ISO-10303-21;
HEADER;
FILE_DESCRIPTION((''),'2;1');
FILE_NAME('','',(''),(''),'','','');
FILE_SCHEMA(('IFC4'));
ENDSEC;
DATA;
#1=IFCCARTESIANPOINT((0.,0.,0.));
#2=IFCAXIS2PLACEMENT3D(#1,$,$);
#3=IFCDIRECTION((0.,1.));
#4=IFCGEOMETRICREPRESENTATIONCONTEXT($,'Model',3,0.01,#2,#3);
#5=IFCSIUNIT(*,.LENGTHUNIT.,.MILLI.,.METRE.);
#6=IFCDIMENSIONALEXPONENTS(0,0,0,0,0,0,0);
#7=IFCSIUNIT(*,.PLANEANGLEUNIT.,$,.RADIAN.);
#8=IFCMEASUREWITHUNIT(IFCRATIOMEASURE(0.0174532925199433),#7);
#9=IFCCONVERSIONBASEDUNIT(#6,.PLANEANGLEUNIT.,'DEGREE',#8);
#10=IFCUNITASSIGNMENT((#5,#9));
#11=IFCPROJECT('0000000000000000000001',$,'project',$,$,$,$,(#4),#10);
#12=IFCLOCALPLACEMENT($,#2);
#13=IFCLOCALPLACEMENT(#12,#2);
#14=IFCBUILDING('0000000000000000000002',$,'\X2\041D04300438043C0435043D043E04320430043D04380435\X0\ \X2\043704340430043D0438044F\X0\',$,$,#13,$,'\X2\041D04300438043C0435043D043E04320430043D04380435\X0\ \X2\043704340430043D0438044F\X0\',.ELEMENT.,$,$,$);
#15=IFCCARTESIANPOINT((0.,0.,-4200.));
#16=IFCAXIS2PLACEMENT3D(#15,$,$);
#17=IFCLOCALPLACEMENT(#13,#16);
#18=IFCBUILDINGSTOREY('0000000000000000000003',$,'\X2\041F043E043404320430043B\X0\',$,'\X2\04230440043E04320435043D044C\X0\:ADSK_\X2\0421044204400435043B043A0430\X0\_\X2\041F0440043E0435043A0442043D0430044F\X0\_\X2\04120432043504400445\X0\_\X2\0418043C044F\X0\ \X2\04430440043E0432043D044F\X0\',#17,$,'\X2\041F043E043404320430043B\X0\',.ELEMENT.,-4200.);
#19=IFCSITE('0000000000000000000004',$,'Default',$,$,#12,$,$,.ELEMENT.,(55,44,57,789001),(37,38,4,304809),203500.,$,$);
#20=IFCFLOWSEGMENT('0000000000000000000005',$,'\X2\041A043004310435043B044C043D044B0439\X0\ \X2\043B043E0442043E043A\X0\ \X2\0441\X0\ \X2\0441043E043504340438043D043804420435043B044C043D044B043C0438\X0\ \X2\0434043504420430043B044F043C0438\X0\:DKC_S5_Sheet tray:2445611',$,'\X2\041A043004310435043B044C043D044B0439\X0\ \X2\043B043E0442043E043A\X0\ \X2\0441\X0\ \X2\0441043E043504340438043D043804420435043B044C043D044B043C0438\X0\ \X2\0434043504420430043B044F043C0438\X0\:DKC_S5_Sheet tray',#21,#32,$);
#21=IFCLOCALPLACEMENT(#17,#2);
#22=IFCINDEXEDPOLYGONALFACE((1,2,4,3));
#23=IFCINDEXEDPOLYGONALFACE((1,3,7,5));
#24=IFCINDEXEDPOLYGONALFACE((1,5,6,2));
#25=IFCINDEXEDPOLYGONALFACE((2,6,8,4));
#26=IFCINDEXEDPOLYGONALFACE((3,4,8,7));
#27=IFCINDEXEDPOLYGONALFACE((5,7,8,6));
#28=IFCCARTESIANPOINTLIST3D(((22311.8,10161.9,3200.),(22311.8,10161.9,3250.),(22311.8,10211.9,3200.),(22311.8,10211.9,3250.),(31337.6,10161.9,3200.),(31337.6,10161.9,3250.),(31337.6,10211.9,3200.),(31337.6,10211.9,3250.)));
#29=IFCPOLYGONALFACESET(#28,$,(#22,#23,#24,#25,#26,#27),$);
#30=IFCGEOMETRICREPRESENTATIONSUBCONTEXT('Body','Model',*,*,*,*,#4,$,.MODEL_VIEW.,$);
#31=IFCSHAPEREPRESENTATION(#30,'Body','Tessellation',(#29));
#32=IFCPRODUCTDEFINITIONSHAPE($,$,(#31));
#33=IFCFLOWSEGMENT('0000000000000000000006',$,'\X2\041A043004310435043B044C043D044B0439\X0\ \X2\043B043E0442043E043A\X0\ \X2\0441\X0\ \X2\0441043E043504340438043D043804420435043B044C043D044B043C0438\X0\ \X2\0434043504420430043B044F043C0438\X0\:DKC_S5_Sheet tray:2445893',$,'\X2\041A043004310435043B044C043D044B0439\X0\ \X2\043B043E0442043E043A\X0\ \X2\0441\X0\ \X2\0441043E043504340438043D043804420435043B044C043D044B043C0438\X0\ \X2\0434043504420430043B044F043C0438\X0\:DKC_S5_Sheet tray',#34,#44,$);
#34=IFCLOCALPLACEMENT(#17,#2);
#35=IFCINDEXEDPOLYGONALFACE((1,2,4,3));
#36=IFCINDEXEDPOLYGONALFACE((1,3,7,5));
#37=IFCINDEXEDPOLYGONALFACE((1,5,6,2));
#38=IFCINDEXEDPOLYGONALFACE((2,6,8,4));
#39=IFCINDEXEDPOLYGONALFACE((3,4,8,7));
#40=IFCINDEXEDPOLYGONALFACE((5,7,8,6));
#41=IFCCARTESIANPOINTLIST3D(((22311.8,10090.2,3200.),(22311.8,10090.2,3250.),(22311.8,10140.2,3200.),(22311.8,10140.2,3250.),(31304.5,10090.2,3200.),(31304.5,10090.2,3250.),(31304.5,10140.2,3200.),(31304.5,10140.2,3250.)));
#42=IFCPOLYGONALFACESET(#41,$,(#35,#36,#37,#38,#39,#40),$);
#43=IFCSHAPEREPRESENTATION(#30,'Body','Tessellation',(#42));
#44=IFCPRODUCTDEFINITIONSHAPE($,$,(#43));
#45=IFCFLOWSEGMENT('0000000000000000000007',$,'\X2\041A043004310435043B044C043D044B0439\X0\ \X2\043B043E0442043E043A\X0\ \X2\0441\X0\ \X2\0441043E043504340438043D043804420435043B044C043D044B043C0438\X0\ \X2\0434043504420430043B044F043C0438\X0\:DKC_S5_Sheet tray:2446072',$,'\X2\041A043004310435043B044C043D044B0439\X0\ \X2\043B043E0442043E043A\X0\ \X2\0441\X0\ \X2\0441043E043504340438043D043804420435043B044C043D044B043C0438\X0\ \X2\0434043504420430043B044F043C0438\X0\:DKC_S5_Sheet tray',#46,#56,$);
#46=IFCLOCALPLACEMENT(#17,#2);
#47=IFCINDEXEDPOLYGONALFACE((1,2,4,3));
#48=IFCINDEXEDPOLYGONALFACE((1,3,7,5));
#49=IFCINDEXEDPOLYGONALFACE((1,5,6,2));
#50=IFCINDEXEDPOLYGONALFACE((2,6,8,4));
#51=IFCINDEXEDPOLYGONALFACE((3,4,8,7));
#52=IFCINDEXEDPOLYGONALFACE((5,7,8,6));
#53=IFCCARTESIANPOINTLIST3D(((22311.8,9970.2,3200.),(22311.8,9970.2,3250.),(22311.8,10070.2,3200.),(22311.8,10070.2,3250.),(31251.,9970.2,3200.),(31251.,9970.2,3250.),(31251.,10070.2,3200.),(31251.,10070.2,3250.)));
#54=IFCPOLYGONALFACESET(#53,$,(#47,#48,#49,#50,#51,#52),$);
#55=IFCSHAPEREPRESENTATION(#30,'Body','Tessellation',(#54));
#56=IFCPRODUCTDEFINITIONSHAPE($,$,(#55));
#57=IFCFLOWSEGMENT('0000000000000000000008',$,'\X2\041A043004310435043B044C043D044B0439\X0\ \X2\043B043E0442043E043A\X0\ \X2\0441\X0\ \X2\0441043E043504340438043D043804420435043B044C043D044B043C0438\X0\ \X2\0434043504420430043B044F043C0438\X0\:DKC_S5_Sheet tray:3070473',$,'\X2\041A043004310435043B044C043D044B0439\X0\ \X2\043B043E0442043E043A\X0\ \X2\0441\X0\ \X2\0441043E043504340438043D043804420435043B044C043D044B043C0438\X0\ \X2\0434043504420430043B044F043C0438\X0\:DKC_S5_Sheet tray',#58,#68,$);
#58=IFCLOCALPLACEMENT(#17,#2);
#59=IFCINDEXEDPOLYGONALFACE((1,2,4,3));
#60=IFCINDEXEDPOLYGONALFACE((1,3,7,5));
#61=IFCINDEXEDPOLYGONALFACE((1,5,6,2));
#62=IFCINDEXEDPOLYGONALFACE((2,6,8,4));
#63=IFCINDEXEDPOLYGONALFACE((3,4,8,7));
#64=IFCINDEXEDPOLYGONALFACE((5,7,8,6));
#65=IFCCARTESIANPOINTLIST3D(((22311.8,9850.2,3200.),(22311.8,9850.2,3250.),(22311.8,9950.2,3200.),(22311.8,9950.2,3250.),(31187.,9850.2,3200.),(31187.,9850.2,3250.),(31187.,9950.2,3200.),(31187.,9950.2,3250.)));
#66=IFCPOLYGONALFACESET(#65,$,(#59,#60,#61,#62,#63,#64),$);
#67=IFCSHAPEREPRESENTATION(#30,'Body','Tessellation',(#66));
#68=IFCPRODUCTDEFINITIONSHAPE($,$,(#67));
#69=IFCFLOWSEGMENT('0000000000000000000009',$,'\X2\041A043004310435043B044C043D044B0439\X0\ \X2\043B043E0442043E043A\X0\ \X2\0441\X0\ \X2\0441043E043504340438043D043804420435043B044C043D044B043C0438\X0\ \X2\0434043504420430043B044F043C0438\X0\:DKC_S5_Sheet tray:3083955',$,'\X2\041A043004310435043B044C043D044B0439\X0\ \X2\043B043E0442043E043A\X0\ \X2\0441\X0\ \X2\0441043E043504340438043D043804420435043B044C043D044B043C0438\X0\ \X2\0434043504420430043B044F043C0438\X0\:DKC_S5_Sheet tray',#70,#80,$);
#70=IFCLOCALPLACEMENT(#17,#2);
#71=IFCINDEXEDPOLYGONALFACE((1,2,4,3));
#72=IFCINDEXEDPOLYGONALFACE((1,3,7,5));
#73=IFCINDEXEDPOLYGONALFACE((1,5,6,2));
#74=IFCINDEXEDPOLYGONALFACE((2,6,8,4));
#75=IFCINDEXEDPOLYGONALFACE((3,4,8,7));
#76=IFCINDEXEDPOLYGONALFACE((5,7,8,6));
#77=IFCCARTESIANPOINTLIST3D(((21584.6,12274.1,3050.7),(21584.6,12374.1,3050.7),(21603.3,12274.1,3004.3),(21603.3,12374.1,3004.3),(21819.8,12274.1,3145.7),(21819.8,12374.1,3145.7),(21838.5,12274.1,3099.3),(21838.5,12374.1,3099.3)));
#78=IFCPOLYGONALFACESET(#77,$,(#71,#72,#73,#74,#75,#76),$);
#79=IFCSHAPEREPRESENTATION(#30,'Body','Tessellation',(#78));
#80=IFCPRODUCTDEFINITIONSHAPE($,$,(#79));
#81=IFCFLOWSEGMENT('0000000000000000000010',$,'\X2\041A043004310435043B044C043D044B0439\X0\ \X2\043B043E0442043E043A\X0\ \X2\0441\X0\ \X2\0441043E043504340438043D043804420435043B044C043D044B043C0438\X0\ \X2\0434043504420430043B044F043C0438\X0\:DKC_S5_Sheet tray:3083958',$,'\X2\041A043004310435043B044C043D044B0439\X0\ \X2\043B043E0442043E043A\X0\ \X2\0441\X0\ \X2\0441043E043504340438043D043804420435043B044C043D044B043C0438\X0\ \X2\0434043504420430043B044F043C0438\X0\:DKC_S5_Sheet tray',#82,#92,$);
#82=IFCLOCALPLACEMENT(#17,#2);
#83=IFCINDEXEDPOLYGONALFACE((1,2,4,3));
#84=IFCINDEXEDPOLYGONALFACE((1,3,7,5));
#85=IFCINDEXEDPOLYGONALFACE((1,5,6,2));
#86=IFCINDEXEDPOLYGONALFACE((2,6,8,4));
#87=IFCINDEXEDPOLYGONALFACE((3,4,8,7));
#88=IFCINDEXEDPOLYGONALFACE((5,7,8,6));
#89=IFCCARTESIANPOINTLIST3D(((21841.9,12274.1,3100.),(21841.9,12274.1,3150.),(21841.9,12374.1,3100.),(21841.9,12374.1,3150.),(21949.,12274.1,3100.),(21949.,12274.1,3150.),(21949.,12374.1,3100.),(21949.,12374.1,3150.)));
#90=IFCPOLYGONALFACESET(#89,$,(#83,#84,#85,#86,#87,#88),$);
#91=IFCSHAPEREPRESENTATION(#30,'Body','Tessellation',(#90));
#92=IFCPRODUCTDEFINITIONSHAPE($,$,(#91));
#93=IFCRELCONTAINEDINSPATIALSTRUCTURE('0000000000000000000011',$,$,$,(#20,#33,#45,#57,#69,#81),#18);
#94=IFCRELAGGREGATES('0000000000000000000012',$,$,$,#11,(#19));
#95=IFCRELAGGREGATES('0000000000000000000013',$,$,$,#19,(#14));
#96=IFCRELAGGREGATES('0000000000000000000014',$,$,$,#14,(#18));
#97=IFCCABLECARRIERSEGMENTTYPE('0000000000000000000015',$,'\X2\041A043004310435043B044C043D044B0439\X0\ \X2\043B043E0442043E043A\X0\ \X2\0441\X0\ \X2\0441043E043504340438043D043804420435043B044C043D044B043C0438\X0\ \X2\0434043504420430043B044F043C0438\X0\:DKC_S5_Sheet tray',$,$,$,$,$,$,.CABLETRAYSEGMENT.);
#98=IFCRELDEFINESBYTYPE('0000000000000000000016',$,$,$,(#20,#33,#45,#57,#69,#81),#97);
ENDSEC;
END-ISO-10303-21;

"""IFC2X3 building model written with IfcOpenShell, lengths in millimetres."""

from ifc_helpers import new_model, entity, si_unit, converted_unit, direction, frame, frame_2d, origin, origin_2d_with_axis, place, context, subcontext, project, spatial, rectangle, extrude, type_object, element, save


model = new_model("IFC2X3")

# Units and contexts
model_context = context("Model", 3, precision=0.01, world=origin(), true_north=direction((0.0, 1.0)))
body_context = subcontext(model_context, "Body", "Model", "MODEL_VIEW")
ifc_project = project(units=[si_unit("LENGTHUNIT", "METRE", prefix="MILLI"), converted_unit("PLANEANGLEUNIT", "DEGREE", entity("IfcRatioMeasure", 0.0174532925199433), si_unit("PLANEANGLEUNIT", "RADIAN"), dimensions=[0, 0, 0, 0, 0, 0, 0])], contexts=[model_context])

# Site, building, storey
site_placement = place(None, origin())
site = spatial("IfcSite", under=ifc_project, at=site_placement, Name="Default", CompositionType="ELEMENT", RefLatitude=(55, 44, 57, 789001), RefLongitude=(37, 38, 4, 304809), RefElevation=203500.0)
building_placement = place(site_placement, origin())
building = spatial("IfcBuilding", under=site, at=building_placement, Name="Наименование здания", LongName="Наименование здания", CompositionType="ELEMENT")
storey_placement = place(building_placement, frame((0.0, 0.0, -4200.0)))
storey = spatial("IfcBuildingStorey", under=building, at=storey_placement, Name="Подвал", ObjectType="Уровень:ADSK_Стрелка_Проектная_Вверх_Имя уровня", LongName="Подвал", CompositionType="ELEMENT", Elevation=-4200.0)

# Flow segments
cable_carrier_segment_type = type_object("IfcCableCarrierSegmentType", Name="Кабельный лоток с соединительными деталями:DKC_S5_Sheet tray", PredefinedType="CABLETRAYSEGMENT")
flow_segment_1_placement = place(storey_placement, frame((22311.8, 10161.9, 3200.0)))
element("IfcFlowSegment", 1, at=flow_segment_1_placement, inside=storey, type_object=cable_carrier_segment_type, Name="Кабельный лоток с соединительными деталями:DKC_S5_Sheet tray:2445611", ObjectType="Кабельный лоток с соединительными деталями:DKC_S5_Sheet tray", context=body_context, shape_type="SweptSolid", body=[
    extrude(rectangle(XDim=9025.9, YDim=50.0, at=origin_2d_with_axis()), frame((4512.9, 25.0, 0.0)), (0.0, 0.0, 1.0), 50.0),
])
flow_segment_2_placement = place(storey_placement, frame((22311.8, 10090.1, 3200.0)))
element("IfcFlowSegment", 2, at=flow_segment_2_placement, inside=storey, type_object=cable_carrier_segment_type, Name="Кабельный лоток с соединительными деталями:DKC_S5_Sheet tray:2445893", ObjectType="Кабельный лоток с соединительными деталями:DKC_S5_Sheet tray", context=body_context, shape_type="SweptSolid", body=[
    extrude(rectangle(XDim=8992.7, YDim=50.0, at=origin_2d_with_axis()), frame((4496.4, 25.0, 0.0)), (0.0, 0.0, 1.0), 50.0),
])
flow_segment_3_placement = place(storey_placement, frame((22311.8, 9970.1, 3200.0)))
element("IfcFlowSegment", 3, at=flow_segment_3_placement, inside=storey, type_object=cable_carrier_segment_type, Name="Кабельный лоток с соединительными деталями:DKC_S5_Sheet tray:2446072", ObjectType="Кабельный лоток с соединительными деталями:DKC_S5_Sheet tray", context=body_context, shape_type="SweptSolid", body=[
    extrude(rectangle(XDim=8939.2, YDim=100.0, at=origin_2d_with_axis()), frame((4469.6, 50.0, 0.0)), (0.0, 0.0, 1.0), 50.0),
])
flow_segment_4_placement = place(storey_placement, frame((22311.8, 9850.1, 3200.0)))
element("IfcFlowSegment", 4, at=flow_segment_4_placement, inside=storey, type_object=cable_carrier_segment_type, Name="Кабельный лоток с соединительными деталями:DKC_S5_Sheet tray:3070473", ObjectType="Кабельный лоток с соединительными деталями:DKC_S5_Sheet tray", context=body_context, shape_type="SweptSolid", body=[
    extrude(rectangle(XDim=8875.2, YDim=100.0, at=origin_2d_with_axis()), frame((4437.6, 50.0, 0.0)), (0.0, 0.0, 1.0), 50.0),
])
flow_segment_5_placement = place(storey_placement, frame((21584.6, 12274.1, 3004.3)))
element("IfcFlowSegment", 5, at=flow_segment_5_placement, inside=storey, type_object=cable_carrier_segment_type, Name="Кабельный лоток с соединительными деталями:DKC_S5_Sheet tray:3083955", ObjectType="Кабельный лоток с соединительными деталями:DKC_S5_Sheet tray", context=body_context, shape_type="SweptSolid", body=[
    extrude(rectangle(XDim=50.0, YDim=100.0, at=frame_2d((0.0, 0.0), x_axis=(0.0, 1.0))), frame((9.4, 50.0, 23.2), z_axis=(0.927184, 0.0, 0.374607), x_axis=(0.0, 1.0, 0.0)), (0.0, 0.0, 1.0), 253.7),
])
flow_segment_6_placement = place(storey_placement, frame((21841.9, 12274.1, 3100.0)))
element("IfcFlowSegment", 6, at=flow_segment_6_placement, inside=storey, type_object=cable_carrier_segment_type, Name="Кабельный лоток с соединительными деталями:DKC_S5_Sheet tray:3083958", ObjectType="Кабельный лоток с соединительными деталями:DKC_S5_Sheet tray", context=body_context, shape_type="SweptSolid", body=[
    extrude(rectangle(XDim=107.1, YDim=100.0, at=origin_2d_with_axis()), frame((53.5, 50.0, 0.0)), (0.0, 0.0, 1.0), 50.0),
])

save(model, "model.ifc")
